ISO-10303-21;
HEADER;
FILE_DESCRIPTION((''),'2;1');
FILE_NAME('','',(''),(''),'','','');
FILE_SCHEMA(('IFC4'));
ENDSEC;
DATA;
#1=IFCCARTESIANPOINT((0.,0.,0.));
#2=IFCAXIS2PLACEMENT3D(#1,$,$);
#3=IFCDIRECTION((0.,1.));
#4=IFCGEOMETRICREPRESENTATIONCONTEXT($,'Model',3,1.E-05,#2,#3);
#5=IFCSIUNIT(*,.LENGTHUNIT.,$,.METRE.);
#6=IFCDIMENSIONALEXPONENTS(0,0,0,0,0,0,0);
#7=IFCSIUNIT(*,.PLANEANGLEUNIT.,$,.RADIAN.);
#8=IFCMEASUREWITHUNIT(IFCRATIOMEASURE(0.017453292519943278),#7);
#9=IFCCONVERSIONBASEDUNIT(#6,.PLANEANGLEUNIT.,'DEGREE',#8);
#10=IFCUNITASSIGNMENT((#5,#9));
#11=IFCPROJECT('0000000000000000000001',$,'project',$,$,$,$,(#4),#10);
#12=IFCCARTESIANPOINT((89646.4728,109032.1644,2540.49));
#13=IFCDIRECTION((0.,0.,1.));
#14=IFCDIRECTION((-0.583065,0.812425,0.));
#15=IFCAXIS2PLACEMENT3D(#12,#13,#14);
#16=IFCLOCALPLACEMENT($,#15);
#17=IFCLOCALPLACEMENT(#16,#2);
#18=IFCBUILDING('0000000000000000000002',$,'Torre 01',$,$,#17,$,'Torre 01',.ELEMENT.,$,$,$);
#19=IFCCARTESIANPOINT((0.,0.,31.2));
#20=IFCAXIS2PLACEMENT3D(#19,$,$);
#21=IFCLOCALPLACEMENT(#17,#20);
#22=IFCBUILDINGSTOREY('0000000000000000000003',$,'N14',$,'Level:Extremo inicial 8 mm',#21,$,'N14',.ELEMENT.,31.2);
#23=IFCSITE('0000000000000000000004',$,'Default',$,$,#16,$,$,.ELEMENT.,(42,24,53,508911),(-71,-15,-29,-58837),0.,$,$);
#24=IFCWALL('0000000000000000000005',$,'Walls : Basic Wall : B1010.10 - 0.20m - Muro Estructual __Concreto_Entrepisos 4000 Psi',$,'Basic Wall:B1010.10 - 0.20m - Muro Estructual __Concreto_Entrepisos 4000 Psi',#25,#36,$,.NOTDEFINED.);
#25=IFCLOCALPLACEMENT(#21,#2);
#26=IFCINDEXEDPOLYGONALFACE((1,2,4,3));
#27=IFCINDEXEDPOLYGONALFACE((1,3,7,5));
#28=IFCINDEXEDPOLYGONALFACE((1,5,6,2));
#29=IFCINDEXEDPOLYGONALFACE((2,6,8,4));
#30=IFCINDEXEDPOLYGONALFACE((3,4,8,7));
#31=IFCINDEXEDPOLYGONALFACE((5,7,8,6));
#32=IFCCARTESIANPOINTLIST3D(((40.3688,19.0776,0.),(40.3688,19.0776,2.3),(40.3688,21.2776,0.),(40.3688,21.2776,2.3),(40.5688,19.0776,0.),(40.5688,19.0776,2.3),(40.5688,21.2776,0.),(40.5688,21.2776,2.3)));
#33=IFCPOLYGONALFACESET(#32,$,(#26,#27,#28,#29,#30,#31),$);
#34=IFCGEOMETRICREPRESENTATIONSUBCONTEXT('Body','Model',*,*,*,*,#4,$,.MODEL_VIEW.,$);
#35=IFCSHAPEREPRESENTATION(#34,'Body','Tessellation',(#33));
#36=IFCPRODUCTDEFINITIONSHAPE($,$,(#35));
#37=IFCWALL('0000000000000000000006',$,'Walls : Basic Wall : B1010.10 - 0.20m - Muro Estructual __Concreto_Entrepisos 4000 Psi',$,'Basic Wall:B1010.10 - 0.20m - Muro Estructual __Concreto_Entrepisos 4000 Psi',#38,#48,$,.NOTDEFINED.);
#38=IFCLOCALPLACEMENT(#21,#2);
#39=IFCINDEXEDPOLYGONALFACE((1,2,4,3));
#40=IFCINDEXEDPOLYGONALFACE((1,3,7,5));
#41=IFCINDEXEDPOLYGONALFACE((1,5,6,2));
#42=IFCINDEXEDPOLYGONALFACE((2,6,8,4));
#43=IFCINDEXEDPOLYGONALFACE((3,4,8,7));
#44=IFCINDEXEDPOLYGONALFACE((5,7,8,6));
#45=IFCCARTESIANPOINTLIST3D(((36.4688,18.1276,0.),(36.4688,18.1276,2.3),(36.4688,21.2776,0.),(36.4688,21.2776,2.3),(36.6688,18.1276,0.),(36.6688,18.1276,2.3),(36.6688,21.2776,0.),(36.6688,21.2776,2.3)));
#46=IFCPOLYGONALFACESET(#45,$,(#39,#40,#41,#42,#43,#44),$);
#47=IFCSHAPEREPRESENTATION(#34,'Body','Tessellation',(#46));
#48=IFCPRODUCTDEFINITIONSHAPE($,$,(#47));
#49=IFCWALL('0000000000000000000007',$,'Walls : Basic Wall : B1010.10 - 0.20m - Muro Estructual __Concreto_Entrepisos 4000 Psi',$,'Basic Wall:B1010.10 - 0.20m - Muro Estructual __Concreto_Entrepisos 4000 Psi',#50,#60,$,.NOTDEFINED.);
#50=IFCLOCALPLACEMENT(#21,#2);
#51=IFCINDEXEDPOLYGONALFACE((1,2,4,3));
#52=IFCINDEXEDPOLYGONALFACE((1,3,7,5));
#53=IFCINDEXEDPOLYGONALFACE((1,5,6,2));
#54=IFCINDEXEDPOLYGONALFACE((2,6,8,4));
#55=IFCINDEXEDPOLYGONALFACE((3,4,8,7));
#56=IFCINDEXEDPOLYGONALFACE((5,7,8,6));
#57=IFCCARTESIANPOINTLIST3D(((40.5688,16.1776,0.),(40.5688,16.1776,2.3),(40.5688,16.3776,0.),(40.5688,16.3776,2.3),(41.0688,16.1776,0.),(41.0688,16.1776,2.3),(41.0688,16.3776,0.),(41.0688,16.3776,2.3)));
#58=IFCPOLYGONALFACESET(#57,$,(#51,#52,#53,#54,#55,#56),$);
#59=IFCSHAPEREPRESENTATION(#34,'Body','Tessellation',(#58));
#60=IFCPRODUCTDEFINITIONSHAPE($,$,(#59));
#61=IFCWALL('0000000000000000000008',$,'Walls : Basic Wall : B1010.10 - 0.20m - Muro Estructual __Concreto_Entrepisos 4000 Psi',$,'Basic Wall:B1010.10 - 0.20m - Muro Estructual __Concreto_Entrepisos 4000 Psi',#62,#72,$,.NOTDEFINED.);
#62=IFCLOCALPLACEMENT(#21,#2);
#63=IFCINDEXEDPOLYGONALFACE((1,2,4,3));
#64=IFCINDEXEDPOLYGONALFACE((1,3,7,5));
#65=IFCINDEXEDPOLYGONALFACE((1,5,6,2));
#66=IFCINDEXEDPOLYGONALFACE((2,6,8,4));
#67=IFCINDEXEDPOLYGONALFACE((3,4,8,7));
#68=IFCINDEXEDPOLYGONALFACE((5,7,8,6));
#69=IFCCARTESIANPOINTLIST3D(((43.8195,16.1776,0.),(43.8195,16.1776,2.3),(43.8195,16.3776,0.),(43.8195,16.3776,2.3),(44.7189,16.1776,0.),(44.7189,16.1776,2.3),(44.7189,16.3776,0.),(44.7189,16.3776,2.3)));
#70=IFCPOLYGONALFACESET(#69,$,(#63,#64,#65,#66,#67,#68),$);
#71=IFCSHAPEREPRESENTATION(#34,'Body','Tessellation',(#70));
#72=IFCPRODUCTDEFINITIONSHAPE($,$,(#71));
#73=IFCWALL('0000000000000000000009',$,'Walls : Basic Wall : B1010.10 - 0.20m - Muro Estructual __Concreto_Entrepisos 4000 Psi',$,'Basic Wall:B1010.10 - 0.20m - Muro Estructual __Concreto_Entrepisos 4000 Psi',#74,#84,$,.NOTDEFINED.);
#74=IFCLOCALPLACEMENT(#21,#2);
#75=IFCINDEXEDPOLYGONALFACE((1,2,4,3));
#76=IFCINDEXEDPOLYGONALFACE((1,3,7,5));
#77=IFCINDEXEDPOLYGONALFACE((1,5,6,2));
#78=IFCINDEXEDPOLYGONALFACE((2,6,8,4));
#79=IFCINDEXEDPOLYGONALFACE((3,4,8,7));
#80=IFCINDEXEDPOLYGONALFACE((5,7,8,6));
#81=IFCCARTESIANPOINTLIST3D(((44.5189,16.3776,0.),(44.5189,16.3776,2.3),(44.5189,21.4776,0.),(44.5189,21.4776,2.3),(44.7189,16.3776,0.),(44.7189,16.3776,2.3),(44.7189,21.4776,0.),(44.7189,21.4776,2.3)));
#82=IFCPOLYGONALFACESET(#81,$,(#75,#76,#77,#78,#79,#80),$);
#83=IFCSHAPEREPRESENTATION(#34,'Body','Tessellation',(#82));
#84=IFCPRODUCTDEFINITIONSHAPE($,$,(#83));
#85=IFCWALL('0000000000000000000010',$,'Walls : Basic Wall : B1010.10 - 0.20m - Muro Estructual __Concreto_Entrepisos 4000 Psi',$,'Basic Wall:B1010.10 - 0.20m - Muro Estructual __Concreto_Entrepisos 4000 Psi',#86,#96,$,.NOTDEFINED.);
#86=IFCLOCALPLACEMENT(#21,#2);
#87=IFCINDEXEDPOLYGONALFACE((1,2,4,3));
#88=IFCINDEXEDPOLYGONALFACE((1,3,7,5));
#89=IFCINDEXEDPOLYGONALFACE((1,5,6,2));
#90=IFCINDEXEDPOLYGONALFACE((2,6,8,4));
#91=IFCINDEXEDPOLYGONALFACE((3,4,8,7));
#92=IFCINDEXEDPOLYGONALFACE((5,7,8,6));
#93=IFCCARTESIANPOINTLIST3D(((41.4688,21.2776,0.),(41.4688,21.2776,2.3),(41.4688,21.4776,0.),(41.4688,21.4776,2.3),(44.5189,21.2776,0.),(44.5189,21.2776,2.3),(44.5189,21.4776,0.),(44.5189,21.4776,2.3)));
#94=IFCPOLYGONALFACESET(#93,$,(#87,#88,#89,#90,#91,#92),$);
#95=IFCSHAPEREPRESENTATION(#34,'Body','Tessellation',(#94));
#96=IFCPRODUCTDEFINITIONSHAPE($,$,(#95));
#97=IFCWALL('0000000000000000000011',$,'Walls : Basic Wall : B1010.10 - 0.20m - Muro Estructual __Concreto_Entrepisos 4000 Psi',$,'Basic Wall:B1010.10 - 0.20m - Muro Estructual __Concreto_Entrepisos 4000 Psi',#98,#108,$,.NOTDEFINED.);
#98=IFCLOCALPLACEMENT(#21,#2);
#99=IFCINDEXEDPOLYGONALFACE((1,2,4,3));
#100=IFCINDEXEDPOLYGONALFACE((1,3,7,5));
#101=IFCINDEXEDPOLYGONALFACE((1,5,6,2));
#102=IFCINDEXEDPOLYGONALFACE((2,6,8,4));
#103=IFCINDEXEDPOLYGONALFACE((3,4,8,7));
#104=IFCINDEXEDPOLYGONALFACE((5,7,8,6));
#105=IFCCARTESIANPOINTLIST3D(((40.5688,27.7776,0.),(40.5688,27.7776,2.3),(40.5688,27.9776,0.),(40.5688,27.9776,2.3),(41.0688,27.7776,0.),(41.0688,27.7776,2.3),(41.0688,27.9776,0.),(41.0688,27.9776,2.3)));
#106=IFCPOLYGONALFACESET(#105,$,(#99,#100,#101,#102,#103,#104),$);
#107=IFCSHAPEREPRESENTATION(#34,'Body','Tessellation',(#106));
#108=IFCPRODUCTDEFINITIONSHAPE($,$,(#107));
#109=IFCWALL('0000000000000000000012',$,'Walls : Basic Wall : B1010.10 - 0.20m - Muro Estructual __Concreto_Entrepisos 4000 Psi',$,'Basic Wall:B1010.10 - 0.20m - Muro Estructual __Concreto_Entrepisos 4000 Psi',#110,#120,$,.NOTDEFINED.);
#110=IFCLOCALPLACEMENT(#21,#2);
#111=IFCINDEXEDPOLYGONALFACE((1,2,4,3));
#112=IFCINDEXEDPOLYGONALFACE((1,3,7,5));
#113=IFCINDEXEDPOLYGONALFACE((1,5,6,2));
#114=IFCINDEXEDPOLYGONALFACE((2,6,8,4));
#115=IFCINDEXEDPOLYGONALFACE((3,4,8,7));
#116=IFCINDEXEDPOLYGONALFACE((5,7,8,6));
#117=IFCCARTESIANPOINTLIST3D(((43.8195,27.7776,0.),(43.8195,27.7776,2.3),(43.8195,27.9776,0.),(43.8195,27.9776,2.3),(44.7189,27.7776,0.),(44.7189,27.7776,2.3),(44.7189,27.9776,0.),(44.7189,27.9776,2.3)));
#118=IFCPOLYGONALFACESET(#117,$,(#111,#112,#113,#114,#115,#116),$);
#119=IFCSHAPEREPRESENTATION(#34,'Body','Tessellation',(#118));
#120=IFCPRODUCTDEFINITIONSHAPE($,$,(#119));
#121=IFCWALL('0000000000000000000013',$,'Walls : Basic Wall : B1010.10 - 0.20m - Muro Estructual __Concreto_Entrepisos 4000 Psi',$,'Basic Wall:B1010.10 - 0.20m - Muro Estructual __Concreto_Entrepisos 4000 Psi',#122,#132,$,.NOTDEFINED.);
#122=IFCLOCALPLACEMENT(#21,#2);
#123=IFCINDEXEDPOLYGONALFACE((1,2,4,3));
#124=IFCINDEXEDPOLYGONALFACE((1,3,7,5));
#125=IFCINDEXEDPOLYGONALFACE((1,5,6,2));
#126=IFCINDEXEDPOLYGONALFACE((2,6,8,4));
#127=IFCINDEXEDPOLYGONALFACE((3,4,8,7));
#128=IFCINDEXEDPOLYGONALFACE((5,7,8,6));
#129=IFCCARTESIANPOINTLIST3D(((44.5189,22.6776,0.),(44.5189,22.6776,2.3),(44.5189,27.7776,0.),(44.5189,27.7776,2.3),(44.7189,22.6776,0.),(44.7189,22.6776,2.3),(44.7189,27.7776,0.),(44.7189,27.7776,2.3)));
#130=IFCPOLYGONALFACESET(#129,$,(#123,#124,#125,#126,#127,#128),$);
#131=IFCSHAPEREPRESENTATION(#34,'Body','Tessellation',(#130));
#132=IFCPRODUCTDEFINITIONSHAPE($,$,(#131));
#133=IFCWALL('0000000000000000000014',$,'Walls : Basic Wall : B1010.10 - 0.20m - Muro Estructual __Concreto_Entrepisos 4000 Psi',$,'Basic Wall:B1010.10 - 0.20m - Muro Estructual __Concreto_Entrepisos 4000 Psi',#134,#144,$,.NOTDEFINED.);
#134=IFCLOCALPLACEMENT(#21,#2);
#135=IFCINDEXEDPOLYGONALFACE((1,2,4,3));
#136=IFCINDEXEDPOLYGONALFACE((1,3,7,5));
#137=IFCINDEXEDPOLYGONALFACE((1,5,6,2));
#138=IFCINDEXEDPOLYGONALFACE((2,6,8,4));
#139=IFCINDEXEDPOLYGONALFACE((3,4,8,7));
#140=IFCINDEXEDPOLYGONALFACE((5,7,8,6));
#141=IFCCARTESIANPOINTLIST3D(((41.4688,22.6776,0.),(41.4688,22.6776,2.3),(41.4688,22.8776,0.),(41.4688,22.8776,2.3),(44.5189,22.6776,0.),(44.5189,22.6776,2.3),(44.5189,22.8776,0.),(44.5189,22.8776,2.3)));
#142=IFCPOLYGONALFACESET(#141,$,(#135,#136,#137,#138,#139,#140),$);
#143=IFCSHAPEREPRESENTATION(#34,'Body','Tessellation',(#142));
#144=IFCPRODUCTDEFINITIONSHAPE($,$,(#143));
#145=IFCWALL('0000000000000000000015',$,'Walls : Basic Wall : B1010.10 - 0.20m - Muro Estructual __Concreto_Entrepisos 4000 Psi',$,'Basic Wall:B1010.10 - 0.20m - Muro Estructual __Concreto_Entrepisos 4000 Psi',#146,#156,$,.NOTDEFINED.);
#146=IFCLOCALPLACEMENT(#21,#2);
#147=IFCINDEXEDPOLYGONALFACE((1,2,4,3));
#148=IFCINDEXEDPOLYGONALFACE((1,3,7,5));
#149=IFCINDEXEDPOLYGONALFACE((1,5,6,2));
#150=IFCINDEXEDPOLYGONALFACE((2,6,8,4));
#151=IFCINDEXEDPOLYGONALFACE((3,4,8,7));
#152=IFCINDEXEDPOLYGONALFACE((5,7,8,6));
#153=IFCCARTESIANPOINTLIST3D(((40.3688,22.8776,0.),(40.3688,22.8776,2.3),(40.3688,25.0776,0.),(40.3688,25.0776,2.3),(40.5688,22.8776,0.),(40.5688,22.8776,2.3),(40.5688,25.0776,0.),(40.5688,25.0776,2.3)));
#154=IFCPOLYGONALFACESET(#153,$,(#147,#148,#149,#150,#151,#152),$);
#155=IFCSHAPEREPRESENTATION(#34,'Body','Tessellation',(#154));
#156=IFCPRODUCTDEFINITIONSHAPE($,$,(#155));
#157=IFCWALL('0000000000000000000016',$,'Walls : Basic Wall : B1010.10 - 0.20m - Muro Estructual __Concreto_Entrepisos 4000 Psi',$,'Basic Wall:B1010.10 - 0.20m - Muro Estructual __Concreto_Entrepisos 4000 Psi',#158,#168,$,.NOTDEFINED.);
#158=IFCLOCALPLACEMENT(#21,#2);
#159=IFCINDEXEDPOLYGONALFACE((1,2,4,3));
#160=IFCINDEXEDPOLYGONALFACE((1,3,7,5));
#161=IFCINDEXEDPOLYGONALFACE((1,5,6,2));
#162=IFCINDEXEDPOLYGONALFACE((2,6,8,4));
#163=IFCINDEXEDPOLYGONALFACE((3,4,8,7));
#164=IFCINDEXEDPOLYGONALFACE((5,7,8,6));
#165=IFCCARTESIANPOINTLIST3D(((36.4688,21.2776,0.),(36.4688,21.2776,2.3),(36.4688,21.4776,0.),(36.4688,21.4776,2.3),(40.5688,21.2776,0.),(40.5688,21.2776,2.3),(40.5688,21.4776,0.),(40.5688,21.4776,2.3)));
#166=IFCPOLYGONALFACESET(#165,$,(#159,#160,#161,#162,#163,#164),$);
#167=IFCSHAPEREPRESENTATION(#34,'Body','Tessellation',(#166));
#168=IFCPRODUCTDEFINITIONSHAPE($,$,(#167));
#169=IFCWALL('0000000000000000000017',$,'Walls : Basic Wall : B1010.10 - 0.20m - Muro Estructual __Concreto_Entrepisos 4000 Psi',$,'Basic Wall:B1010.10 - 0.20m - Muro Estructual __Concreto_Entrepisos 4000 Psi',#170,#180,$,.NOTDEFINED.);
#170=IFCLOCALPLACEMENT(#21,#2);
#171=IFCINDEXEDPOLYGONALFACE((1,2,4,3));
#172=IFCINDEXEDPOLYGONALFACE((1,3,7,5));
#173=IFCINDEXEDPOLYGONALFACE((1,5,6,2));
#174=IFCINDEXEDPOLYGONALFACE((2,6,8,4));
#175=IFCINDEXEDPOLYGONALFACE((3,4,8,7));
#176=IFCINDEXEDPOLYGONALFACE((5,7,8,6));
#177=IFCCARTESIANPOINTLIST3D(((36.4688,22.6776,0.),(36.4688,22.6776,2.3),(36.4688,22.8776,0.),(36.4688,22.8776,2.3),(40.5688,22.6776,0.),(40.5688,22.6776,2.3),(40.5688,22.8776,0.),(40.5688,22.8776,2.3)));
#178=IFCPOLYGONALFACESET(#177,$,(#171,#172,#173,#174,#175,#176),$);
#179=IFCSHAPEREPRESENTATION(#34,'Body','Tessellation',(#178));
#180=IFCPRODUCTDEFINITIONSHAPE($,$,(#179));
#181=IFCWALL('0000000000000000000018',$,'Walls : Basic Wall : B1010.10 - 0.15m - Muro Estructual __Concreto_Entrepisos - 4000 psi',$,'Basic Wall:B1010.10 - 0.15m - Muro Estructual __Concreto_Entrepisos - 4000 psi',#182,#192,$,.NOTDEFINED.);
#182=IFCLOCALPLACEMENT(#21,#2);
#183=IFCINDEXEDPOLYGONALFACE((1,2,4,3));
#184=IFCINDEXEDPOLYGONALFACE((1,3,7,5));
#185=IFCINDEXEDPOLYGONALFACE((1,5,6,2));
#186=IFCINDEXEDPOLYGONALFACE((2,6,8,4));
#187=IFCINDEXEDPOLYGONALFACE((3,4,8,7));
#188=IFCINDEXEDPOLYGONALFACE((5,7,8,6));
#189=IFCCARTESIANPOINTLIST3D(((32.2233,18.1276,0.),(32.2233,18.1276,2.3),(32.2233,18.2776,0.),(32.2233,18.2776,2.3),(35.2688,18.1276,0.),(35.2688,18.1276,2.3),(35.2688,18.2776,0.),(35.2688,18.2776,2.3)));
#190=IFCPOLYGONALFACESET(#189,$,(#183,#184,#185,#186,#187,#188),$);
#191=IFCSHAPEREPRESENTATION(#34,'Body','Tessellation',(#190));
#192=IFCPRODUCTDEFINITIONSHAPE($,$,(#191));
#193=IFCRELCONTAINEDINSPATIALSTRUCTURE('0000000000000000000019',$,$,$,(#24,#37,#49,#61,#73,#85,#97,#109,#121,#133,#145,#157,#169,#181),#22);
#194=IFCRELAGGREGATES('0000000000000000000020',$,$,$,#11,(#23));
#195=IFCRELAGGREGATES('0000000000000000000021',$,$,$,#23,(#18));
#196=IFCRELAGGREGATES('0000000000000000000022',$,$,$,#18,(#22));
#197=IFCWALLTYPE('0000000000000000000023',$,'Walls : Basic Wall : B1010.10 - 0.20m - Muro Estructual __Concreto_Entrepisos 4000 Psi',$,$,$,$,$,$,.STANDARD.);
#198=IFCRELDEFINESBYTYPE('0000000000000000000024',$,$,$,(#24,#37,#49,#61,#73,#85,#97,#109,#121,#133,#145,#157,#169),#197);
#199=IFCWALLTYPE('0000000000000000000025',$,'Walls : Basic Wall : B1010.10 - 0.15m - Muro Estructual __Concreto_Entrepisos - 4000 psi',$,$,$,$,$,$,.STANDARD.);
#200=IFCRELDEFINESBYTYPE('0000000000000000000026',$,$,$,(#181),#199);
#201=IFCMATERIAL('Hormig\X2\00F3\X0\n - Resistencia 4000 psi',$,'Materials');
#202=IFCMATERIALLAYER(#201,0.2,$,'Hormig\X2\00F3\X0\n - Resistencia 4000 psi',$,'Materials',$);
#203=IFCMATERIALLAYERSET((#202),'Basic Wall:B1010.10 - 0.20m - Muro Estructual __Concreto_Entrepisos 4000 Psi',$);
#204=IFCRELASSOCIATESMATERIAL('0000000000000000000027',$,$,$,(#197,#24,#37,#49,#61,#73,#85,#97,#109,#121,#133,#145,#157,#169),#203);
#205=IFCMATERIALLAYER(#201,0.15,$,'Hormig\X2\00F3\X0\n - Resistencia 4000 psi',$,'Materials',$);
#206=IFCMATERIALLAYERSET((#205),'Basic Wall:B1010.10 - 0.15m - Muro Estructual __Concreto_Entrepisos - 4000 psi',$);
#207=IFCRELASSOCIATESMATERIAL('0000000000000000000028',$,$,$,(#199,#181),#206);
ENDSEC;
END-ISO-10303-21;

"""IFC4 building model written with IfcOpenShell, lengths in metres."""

from ifc_helpers import new_model, entity, si_unit, converted_unit, direction, frame, frame_2d, origin, place, context, subcontext, project, spatial, rectangle, extrude, material, layer, layer_set, layer_usage, type_object, element, save


model = new_model("IFC4")

# Units and contexts
model_context = context("Model", 3, precision=1e-05, world=origin(), true_north=direction((0.0, 1.0)))
body_context = subcontext(model_context, "Body", "Model", "MODEL_VIEW")
ifc_project = project(units=[si_unit("LENGTHUNIT", "METRE"), converted_unit("PLANEANGLEUNIT", "DEGREE", entity("IfcRatioMeasure", 0.017453292519943278), si_unit("PLANEANGLEUNIT", "RADIAN"), dimensions=[0, 0, 0, 0, 0, 0, 0])], contexts=[model_context])

# Site, building, storey
site_placement = place(None, frame((89646.4728, 109032.1644, 2540.49), z_axis=(0.0, 0.0, 1.0), x_axis=(-0.583065, 0.812425, 0.0)))
site = spatial("IfcSite", under=ifc_project, at=site_placement, Name="Default", CompositionType="ELEMENT", RefLatitude=(42, 24, 53, 508911), RefLongitude=(-71, -15, -29, -58837), RefElevation=0.0)
building_placement = place(site_placement, origin())
building = spatial("IfcBuilding", under=site, at=building_placement, Name="Torre 01", LongName="Torre 01", CompositionType="ELEMENT")
storey_placement = place(building_placement, frame((0.0, 0.0, 31.2)))
storey = spatial("IfcBuildingStorey", under=building, at=storey_placement, Name="N14", ObjectType="Level:Extremo inicial 8 mm", LongName="N14", CompositionType="ELEMENT", Elevation=31.2)

# Walls
ifc_material = material(Name="Hormigón - Resistencia 4000 psi", Category="Materials")
ifc_layer_1 = layer(ifc_material, 0.2, Name="Hormigón - Resistencia 4000 psi", Category="Materials")
ifc_layer_set_1 = layer_set([ifc_layer_1], Name="Basic Wall:B1010.10 - 0.20m - Muro Estructual __Concreto_Entrepisos 4000 Psi")
ifc_layer_usage_1 = layer_usage(ifc_layer_set_1, "AXIS2", "NEGATIVE", 0.1)
wall_type_1 = type_object("IfcWallType", Name="Walls : Basic Wall : B1010.10 - 0.20m - Muro Estructual __Concreto_Entrepisos 4000 Psi", PredefinedType="STANDARD", material=ifc_layer_set_1)
wall_1_placement = place(storey_placement, frame((40.4688, 21.2776, 0.0), z_axis=(0.0, 0.0, 1.0), x_axis=(0.0, -1.0, 0.0)))
element("IfcWall", 1, at=wall_1_placement, inside=storey, type_object=wall_type_1, material=ifc_layer_usage_1, Name="Walls : Basic Wall : B1010.10 - 0.20m - Muro Estructual __Concreto_Entrepisos 4000 Psi", ObjectType="Basic Wall:B1010.10 - 0.20m - Muro Estructual __Concreto_Entrepisos 4000 Psi", PredefinedType="NOTDEFINED", context=body_context, shape_type="SweptSolid", body=[
    extrude(rectangle(XDim=2.2, YDim=0.2, at=frame_2d((1.1, 0.0), x_axis=(-1.0, 0.0))), origin(), (0.0, 0.0, 1.0), 2.3),
])
ifc_layer_usage_2 = layer_usage(ifc_layer_set_1, "AXIS2", "NEGATIVE", 0.1)
wall_2_placement = place(storey_placement, frame((36.5688, 18.1276, 0.0), z_axis=(0.0, 0.0, 1.0), x_axis=(0.0, 1.0, 0.0)))
element("IfcWall", 2, at=wall_2_placement, inside=storey, type_object=wall_type_1, material=ifc_layer_usage_2, Name="Walls : Basic Wall : B1010.10 - 0.20m - Muro Estructual __Concreto_Entrepisos 4000 Psi", ObjectType="Basic Wall:B1010.10 - 0.20m - Muro Estructual __Concreto_Entrepisos 4000 Psi", PredefinedType="NOTDEFINED", context=body_context, shape_type="SweptSolid", body=[
    extrude(rectangle(XDim=3.15, YDim=0.2, at=frame_2d((1.575, 0.0), x_axis=(-1.0, 0.0))), origin(), (0.0, 0.0, 1.0), 2.3),
])
ifc_layer_usage_3 = layer_usage(ifc_layer_set_1, "AXIS2", "NEGATIVE", 0.1)
wall_3_placement = place(storey_placement, frame((41.0688, 16.2776, 0.0), z_axis=(0.0, 0.0, 1.0), x_axis=(-1.0, 0.0, 0.0)))
element("IfcWall", 3, at=wall_3_placement, inside=storey, type_object=wall_type_1, material=ifc_layer_usage_3, Name="Walls : Basic Wall : B1010.10 - 0.20m - Muro Estructual __Concreto_Entrepisos 4000 Psi", ObjectType="Basic Wall:B1010.10 - 0.20m - Muro Estructual __Concreto_Entrepisos 4000 Psi", PredefinedType="NOTDEFINED", context=body_context, shape_type="SweptSolid", body=[
    extrude(rectangle(XDim=0.5, YDim=0.2, at=frame_2d((0.25, 0.0), x_axis=(-1.0, 0.0))), origin(), (0.0, 0.0, 1.0), 2.3),
])
ifc_layer_usage_4 = layer_usage(ifc_layer_set_1, "AXIS2", "NEGATIVE", 0.1)
wall_4_placement = place(storey_placement, frame((43.8195, 16.2776, 0.0)))
element("IfcWall", 4, at=wall_4_placement, inside=storey, type_object=wall_type_1, material=ifc_layer_usage_4, Name="Walls : Basic Wall : B1010.10 - 0.20m - Muro Estructual __Concreto_Entrepisos 4000 Psi", ObjectType="Basic Wall:B1010.10 - 0.20m - Muro Estructual __Concreto_Entrepisos 4000 Psi", PredefinedType="NOTDEFINED", context=body_context, shape_type="SweptSolid", body=[
    extrude(rectangle(XDim=0.8993, YDim=0.2, at=frame_2d((0.4497, 0.0), x_axis=(-1.0, 0.0))), origin(), (0.0, 0.0, 1.0), 2.3),
])
ifc_layer_usage_5 = layer_usage(ifc_layer_set_1, "AXIS2", "NEGATIVE", 0.1)
wall_5_placement = place(storey_placement, frame((44.6189, 21.4776, 0.0), z_axis=(0.0, 0.0, 1.0), x_axis=(0.0, -1.0, 0.0)))
element("IfcWall", 5, at=wall_5_placement, inside=storey, type_object=wall_type_1, material=ifc_layer_usage_5, Name="Walls : Basic Wall : B1010.10 - 0.20m - Muro Estructual __Concreto_Entrepisos 4000 Psi", ObjectType="Basic Wall:B1010.10 - 0.20m - Muro Estructual __Concreto_Entrepisos 4000 Psi", PredefinedType="NOTDEFINED", context=body_context, shape_type="SweptSolid", body=[
    extrude(rectangle(XDim=5.1, YDim=0.2, at=frame_2d((2.55, 0.0), x_axis=(-1.0, 0.0))), origin(), (0.0, 0.0, 1.0), 2.3),
])
ifc_layer_usage_6 = layer_usage(ifc_layer_set_1, "AXIS2", "NEGATIVE", 0.1)
wall_6_placement = place(storey_placement, frame((41.4688, 21.3776, 0.0)))
element("IfcWall", 6, at=wall_6_placement, inside=storey, type_object=wall_type_1, material=ifc_layer_usage_6, Name="Walls : Basic Wall : B1010.10 - 0.20m - Muro Estructual __Concreto_Entrepisos 4000 Psi", ObjectType="Basic Wall:B1010.10 - 0.20m - Muro Estructual __Concreto_Entrepisos 4000 Psi", PredefinedType="NOTDEFINED", context=body_context, shape_type="SweptSolid", body=[
    extrude(rectangle(XDim=3.05, YDim=0.2, at=frame_2d((1.525, 0.0), x_axis=(-1.0, 0.0))), origin(), (0.0, 0.0, 1.0), 2.3),
])
ifc_layer_usage_7 = layer_usage(ifc_layer_set_1, "AXIS2", "POSITIVE", -0.1)
wall_7_placement = place(storey_placement, frame((41.0688, 27.8776, 0.0), z_axis=(0.0, 0.0, 1.0), x_axis=(-1.0, 0.0, 0.0)))
element("IfcWall", 7, at=wall_7_placement, inside=storey, type_object=wall_type_1, material=ifc_layer_usage_7, Name="Walls : Basic Wall : B1010.10 - 0.20m - Muro Estructual __Concreto_Entrepisos 4000 Psi", ObjectType="Basic Wall:B1010.10 - 0.20m - Muro Estructual __Concreto_Entrepisos 4000 Psi", PredefinedType="NOTDEFINED", context=body_context, shape_type="SweptSolid", body=[
    extrude(rectangle(XDim=0.5, YDim=0.2, at=frame_2d((0.25, 0.0), x_axis=(-1.0, 0.0))), origin(), (0.0, 0.0, 1.0), 2.3),
])
ifc_layer_usage_8 = layer_usage(ifc_layer_set_1, "AXIS2", "POSITIVE", -0.1)
wall_8_placement = place(storey_placement, frame((43.8195, 27.8776, 0.0)))
element("IfcWall", 8, at=wall_8_placement, inside=storey, type_object=wall_type_1, material=ifc_layer_usage_8, Name="Walls : Basic Wall : B1010.10 - 0.20m - Muro Estructual __Concreto_Entrepisos 4000 Psi", ObjectType="Basic Wall:B1010.10 - 0.20m - Muro Estructual __Concreto_Entrepisos 4000 Psi", PredefinedType="NOTDEFINED", context=body_context, shape_type="SweptSolid", body=[
    extrude(rectangle(XDim=0.8993, YDim=0.2, at=frame_2d((0.4497, 0.0), x_axis=(-1.0, 0.0))), origin(), (0.0, 0.0, 1.0), 2.3),
])
ifc_layer_usage_9 = layer_usage(ifc_layer_set_1, "AXIS2", "POSITIVE", -0.1)
wall_9_placement = place(storey_placement, frame((44.6189, 22.6776, 0.0), z_axis=(0.0, 0.0, 1.0), x_axis=(0.0, 1.0, 0.0)))
element("IfcWall", 9, at=wall_9_placement, inside=storey, type_object=wall_type_1, material=ifc_layer_usage_9, Name="Walls : Basic Wall : B1010.10 - 0.20m - Muro Estructual __Concreto_Entrepisos 4000 Psi", ObjectType="Basic Wall:B1010.10 - 0.20m - Muro Estructual __Concreto_Entrepisos 4000 Psi", PredefinedType="NOTDEFINED", context=body_context, shape_type="SweptSolid", body=[
    extrude(rectangle(XDim=5.1, YDim=0.2, at=frame_2d((2.55, 0.0), x_axis=(-1.0, 0.0))), origin(), (0.0, 0.0, 1.0), 2.3),
])
ifc_layer_usage_10 = layer_usage(ifc_layer_set_1, "AXIS2", "POSITIVE", -0.1)
wall_10_placement = place(storey_placement, frame((41.4688, 22.7776, 0.0)))
element("IfcWall", 10, at=wall_10_placement, inside=storey, type_object=wall_type_1, material=ifc_layer_usage_10, Name="Walls : Basic Wall : B1010.10 - 0.20m - Muro Estructual __Concreto_Entrepisos 4000 Psi", ObjectType="Basic Wall:B1010.10 - 0.20m - Muro Estructual __Concreto_Entrepisos 4000 Psi", PredefinedType="NOTDEFINED", context=body_context, shape_type="SweptSolid", body=[
    extrude(rectangle(XDim=3.05, YDim=0.2, at=frame_2d((1.525, 0.0), x_axis=(-1.0, 0.0))), origin(), (0.0, 0.0, 1.0), 2.3),
])
ifc_layer_usage_11 = layer_usage(ifc_layer_set_1, "AXIS2", "POSITIVE", -0.1)
wall_11_placement = place(storey_placement, frame((40.4688, 22.8776, 0.0), z_axis=(0.0, 0.0, 1.0), x_axis=(0.0, 1.0, 0.0)))
element("IfcWall", 11, at=wall_11_placement, inside=storey, type_object=wall_type_1, material=ifc_layer_usage_11, Name="Walls : Basic Wall : B1010.10 - 0.20m - Muro Estructual __Concreto_Entrepisos 4000 Psi", ObjectType="Basic Wall:B1010.10 - 0.20m - Muro Estructual __Concreto_Entrepisos 4000 Psi", PredefinedType="NOTDEFINED", context=body_context, shape_type="SweptSolid", body=[
    extrude(rectangle(XDim=2.2, YDim=0.2, at=frame_2d((1.1, 0.0), x_axis=(-1.0, 0.0))), origin(), (0.0, 0.0, 1.0), 2.3),
])
ifc_layer_usage_12 = layer_usage(ifc_layer_set_1, "AXIS2", "NEGATIVE", 0.1)
wall_12_placement = place(storey_placement, frame((36.4688, 21.3776, 0.0)))
element("IfcWall", 12, at=wall_12_placement, inside=storey, type_object=wall_type_1, material=ifc_layer_usage_12, Name="Walls : Basic Wall : B1010.10 - 0.20m - Muro Estructual __Concreto_Entrepisos 4000 Psi", ObjectType="Basic Wall:B1010.10 - 0.20m - Muro Estructual __Concreto_Entrepisos 4000 Psi", PredefinedType="NOTDEFINED", context=body_context, shape_type="SweptSolid", body=[
    extrude(rectangle(XDim=4.1, YDim=0.2, at=frame_2d((2.05, 0.0), x_axis=(-1.0, 0.0))), origin(), (0.0, 0.0, 1.0), 2.3),
])
ifc_layer_usage_13 = layer_usage(ifc_layer_set_1, "AXIS2", "POSITIVE", -0.1)
wall_13_placement = place(storey_placement, frame((36.4688, 22.7776, 0.0)))
element("IfcWall", 13, at=wall_13_placement, inside=storey, type_object=wall_type_1, material=ifc_layer_usage_13, Name="Walls : Basic Wall : B1010.10 - 0.20m - Muro Estructual __Concreto_Entrepisos 4000 Psi", ObjectType="Basic Wall:B1010.10 - 0.20m - Muro Estructual __Concreto_Entrepisos 4000 Psi", PredefinedType="NOTDEFINED", context=body_context, shape_type="SweptSolid", body=[
    extrude(rectangle(XDim=4.1, YDim=0.2, at=frame_2d((2.05, 0.0), x_axis=(-1.0, 0.0))), origin(), (0.0, 0.0, 1.0), 2.3),
])
ifc_layer_2 = layer(ifc_material, 0.15, Name="Hormigón - Resistencia 4000 psi", Category="Materials")
ifc_layer_set_2 = layer_set([ifc_layer_2], Name="Basic Wall:B1010.10 - 0.15m - Muro Estructual __Concreto_Entrepisos - 4000 psi")
ifc_layer_usage_14 = layer_usage(ifc_layer_set_2, "AXIS2", "NEGATIVE", 0.075)
wall_type_2 = type_object("IfcWallType", Name="Walls : Basic Wall : B1010.10 - 0.15m - Muro Estructual __Concreto_Entrepisos - 4000 psi", PredefinedType="STANDARD", material=ifc_layer_set_2)
wall_14_placement = place(storey_placement, frame((32.2233, 18.2026, 0.0)))
element("IfcWall", 14, at=wall_14_placement, inside=storey, type_object=wall_type_2, material=ifc_layer_usage_14, Name="Walls : Basic Wall : B1010.10 - 0.15m - Muro Estructual __Concreto_Entrepisos - 4000 psi", ObjectType="Basic Wall:B1010.10 - 0.15m - Muro Estructual __Concreto_Entrepisos - 4000 psi", PredefinedType="NOTDEFINED", context=body_context, shape_type="SweptSolid", body=[
    extrude(rectangle(XDim=3.0455, YDim=0.15, at=frame_2d((1.5228, 0.0), x_axis=(-1.0, 0.0))), origin(), (0.0, 0.0, 1.0), 2.3),
])

save(model, "model.ifc")
